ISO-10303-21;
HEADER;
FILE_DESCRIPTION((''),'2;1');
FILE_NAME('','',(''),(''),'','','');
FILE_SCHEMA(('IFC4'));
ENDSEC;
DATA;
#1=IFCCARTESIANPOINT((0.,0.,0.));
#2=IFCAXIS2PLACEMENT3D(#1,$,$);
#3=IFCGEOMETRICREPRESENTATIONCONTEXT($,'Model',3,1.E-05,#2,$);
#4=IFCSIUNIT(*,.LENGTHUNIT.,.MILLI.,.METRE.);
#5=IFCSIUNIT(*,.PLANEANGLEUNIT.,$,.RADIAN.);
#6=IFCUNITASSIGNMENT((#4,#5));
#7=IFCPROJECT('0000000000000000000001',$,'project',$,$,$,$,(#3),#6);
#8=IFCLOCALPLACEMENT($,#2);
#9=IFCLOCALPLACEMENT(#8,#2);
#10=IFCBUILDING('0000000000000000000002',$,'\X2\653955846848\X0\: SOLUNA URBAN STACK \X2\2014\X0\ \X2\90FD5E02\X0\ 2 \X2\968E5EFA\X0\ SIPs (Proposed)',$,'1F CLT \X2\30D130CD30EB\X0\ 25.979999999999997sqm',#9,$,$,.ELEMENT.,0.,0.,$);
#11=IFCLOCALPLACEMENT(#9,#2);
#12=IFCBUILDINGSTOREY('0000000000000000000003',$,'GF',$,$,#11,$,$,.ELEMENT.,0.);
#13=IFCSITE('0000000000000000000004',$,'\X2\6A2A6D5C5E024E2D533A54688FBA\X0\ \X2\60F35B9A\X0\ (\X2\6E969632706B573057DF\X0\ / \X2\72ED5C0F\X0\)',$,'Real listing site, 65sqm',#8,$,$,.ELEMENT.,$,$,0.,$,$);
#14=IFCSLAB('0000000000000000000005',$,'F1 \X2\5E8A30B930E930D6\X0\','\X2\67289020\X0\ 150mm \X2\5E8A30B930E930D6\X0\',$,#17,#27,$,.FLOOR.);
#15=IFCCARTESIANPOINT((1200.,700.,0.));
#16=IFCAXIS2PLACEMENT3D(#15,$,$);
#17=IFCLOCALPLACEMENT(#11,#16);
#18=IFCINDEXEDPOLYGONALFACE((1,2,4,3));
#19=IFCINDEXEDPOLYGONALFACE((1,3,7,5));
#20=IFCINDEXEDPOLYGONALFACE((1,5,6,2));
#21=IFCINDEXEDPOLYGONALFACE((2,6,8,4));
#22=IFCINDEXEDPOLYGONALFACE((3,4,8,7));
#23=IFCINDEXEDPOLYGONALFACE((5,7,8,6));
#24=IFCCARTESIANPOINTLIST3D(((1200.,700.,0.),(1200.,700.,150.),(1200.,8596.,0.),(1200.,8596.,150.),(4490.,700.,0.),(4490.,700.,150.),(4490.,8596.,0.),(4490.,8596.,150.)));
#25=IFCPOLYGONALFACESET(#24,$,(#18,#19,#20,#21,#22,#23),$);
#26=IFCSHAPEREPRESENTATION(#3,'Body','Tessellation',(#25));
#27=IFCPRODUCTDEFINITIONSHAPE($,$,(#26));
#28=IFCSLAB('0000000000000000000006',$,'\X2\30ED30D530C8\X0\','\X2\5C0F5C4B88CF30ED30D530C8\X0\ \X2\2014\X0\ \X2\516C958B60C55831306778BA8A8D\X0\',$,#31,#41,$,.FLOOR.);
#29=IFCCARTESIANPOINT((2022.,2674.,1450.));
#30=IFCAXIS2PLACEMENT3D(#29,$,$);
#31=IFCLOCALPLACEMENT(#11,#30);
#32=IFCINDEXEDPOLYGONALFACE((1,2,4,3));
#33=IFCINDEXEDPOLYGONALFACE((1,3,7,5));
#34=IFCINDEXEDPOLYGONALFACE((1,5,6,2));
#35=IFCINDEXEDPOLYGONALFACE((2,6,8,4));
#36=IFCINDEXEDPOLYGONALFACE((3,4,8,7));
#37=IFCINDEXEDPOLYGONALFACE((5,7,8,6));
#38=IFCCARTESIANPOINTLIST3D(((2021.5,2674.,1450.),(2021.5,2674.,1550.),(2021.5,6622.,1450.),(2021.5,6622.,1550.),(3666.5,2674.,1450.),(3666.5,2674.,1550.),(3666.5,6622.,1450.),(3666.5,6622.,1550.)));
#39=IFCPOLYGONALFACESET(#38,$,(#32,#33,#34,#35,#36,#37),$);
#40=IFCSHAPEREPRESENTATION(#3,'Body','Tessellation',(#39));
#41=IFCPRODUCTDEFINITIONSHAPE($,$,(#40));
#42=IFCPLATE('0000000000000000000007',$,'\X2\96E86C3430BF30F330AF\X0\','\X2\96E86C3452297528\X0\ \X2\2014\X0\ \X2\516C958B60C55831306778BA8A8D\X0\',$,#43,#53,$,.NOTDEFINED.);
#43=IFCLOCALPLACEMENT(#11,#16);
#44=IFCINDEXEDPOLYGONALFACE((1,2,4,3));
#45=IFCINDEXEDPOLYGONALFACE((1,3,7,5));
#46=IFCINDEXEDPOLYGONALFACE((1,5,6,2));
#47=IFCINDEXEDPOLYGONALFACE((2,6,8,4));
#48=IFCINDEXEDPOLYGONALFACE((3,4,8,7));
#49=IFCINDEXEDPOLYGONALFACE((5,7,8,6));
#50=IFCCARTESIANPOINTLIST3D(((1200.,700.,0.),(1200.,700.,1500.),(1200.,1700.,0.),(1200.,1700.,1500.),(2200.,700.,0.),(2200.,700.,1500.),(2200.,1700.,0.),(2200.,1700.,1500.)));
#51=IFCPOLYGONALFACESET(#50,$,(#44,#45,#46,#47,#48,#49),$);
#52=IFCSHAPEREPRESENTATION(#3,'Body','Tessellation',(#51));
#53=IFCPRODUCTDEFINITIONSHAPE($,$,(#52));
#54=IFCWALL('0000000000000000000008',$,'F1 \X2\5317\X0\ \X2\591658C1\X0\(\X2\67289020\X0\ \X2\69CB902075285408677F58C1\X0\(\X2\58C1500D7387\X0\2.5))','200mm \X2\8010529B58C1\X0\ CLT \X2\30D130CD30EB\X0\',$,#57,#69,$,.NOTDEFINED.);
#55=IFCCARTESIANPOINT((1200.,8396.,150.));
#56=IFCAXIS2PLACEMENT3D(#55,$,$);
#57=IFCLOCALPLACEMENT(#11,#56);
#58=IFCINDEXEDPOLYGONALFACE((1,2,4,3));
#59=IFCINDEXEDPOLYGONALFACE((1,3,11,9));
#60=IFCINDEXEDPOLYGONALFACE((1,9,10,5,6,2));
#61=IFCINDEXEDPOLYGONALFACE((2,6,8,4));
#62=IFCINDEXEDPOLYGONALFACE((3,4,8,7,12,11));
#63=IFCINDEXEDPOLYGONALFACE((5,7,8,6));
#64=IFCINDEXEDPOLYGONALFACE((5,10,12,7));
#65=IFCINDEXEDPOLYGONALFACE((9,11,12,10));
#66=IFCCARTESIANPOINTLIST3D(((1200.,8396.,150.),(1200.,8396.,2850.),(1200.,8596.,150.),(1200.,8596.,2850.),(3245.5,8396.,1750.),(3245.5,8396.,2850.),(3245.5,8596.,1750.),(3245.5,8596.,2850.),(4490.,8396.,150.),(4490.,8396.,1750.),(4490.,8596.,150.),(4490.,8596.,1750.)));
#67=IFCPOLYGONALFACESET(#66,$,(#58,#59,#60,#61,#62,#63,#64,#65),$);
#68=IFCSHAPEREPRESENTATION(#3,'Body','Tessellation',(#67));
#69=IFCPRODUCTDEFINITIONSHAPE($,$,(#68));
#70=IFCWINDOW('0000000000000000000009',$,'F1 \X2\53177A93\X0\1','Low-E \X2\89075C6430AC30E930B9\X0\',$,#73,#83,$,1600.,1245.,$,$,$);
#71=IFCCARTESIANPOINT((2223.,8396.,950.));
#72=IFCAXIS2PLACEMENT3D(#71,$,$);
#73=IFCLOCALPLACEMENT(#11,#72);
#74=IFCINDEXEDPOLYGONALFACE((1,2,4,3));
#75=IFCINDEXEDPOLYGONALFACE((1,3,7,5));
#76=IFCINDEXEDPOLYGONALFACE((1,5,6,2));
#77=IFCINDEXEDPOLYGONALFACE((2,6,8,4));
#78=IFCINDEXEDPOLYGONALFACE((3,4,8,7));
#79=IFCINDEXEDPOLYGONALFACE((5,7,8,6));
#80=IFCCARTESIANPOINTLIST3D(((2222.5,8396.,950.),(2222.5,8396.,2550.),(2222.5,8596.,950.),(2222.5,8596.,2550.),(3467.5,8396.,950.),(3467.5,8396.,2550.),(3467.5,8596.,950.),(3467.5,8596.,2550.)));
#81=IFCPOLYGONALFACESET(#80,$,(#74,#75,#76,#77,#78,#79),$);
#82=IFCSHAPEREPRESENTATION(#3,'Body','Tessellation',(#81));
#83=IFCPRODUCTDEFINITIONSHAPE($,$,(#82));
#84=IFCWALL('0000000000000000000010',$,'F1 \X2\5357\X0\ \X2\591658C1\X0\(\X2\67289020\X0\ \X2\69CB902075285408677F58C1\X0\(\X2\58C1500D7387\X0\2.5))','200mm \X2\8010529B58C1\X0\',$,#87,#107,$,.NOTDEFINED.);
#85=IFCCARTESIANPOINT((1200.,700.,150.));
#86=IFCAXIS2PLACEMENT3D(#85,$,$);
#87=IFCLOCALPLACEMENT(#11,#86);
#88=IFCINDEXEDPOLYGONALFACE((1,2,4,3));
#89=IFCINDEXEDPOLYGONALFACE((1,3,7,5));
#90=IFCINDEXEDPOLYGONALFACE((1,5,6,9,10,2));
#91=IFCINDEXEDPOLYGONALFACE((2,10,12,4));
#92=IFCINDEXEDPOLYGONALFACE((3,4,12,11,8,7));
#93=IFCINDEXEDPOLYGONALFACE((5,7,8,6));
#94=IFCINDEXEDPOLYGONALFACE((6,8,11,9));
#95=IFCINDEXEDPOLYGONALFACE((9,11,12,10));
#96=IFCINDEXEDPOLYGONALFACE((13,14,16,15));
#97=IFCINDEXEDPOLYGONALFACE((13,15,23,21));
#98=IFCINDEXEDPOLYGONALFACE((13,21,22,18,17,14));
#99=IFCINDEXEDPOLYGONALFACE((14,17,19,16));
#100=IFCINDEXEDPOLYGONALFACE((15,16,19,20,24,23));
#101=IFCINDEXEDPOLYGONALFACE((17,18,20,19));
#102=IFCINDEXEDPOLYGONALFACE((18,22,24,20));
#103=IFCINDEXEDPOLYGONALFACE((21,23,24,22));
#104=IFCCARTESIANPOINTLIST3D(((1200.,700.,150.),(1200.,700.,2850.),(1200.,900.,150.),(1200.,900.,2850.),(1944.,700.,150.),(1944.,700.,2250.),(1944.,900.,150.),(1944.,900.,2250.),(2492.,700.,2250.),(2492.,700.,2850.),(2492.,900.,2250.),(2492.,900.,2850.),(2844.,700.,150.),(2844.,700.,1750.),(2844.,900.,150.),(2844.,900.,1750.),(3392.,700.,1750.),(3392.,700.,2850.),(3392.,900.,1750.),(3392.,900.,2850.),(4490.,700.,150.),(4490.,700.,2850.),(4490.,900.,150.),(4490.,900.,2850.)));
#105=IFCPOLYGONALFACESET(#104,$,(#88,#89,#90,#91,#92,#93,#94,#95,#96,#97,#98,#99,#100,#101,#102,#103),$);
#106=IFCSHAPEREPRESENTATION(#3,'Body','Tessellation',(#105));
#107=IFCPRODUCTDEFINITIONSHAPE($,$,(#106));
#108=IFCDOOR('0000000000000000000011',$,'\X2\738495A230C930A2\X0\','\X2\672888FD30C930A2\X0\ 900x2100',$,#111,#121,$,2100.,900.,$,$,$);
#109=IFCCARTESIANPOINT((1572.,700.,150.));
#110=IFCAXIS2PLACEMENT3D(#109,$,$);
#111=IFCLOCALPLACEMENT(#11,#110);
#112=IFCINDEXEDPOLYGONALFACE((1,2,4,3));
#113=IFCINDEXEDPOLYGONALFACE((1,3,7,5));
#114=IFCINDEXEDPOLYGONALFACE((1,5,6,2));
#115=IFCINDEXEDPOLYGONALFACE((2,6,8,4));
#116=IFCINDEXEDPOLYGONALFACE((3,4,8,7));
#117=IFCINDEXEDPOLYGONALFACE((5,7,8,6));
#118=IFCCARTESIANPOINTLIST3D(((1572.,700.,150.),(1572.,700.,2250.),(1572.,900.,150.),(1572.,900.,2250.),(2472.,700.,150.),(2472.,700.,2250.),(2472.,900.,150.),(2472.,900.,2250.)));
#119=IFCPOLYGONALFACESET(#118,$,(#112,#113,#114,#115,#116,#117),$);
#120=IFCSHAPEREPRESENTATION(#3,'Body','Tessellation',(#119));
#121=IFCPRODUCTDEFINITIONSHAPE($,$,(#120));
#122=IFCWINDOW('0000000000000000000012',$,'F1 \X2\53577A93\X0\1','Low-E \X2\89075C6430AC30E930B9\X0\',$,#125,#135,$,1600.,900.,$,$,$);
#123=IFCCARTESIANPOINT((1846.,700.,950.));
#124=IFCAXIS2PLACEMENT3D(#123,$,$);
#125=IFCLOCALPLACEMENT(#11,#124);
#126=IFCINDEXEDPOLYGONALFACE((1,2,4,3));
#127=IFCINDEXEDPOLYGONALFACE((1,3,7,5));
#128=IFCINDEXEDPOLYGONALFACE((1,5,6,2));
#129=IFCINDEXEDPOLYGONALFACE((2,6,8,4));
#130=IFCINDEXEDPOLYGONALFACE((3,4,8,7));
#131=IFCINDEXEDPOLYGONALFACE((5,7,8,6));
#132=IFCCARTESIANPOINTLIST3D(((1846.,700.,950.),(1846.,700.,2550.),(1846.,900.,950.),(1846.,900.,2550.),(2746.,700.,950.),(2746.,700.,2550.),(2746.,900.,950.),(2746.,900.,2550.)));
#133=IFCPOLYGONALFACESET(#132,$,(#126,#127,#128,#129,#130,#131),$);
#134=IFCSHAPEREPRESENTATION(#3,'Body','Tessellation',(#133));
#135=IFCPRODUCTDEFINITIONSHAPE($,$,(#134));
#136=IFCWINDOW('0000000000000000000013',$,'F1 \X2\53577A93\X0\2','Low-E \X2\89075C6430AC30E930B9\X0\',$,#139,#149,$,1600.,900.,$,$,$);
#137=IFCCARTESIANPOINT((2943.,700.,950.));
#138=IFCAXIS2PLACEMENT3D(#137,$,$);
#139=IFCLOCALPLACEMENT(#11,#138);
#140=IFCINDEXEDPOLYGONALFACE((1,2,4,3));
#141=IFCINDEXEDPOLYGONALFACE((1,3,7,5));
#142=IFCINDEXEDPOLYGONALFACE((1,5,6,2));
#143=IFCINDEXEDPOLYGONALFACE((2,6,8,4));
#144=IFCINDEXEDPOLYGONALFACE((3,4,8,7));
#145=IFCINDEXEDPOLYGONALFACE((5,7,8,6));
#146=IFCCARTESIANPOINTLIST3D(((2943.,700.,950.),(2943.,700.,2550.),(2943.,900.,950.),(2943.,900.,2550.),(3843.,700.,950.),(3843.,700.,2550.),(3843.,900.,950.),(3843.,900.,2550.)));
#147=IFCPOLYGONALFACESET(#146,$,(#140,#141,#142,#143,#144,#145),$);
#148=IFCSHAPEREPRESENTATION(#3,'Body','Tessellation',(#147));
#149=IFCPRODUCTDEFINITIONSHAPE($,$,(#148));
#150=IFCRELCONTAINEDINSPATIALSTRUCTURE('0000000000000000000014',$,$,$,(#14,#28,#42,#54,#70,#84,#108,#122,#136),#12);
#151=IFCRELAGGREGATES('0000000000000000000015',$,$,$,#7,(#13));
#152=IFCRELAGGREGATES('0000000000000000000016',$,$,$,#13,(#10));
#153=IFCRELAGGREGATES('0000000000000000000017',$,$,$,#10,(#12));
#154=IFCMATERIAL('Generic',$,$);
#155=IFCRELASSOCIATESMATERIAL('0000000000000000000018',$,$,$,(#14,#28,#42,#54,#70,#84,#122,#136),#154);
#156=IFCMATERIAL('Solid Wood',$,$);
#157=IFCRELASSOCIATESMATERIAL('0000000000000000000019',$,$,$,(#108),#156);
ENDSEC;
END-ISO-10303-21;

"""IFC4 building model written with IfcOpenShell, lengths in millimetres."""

from ifc_helpers import new_model, si_unit, frame, frame_2d, origin, place, context, project, spatial, rectangle, extrude, material, element, fill, save


model = new_model("IFC4")

# Units and contexts
model_context = context("Model", 3, precision=1e-05, world=origin())
ifc_project = project(units=[si_unit("LENGTHUNIT", "METRE", prefix="MILLI"), si_unit("PLANEANGLEUNIT", "RADIAN")], contexts=[model_context])

# Site, building, storey
site_placement = place(None, origin())
site = spatial("IfcSite", under=ifc_project, at=site_placement, Name="横浜市中区周辺 想定 (準防火地域 / 狭小)", ObjectType="Real listing site, 65sqm", CompositionType="ELEMENT", RefElevation=0.0)
building_placement = place(site_placement, origin())
building = spatial("IfcBuilding", under=site, at=building_placement, Name="改善案: SOLUNA URBAN STACK — 都市 2 階建 SIPs (Proposed)", ObjectType="1F CLT パネル 25.979999999999997sqm", CompositionType="ELEMENT", ElevationOfRefHeight=0.0, ElevationOfTerrain=0.0)
storey_placement = place(building_placement, origin())
storey = spatial("IfcBuildingStorey", under=building, at=storey_placement, Name="GF", CompositionType="ELEMENT", Elevation=0.0)

# Slabs
ifc_material_1 = material(Name="Generic")
slab_1_placement = place(storey_placement, frame((1200.0, 700.0, 0.0)))
element("IfcSlab", 1, at=slab_1_placement, inside=storey, material=ifc_material_1, Name="F1 床スラブ", Description="木造 150mm 床スラブ", PredefinedType="FLOOR", context=model_context, shape_type="SweptSolid", body=[
    extrude(rectangle(XDim=3290.0, YDim=7896.0, at=frame_2d((1645.0, 3948.0))), frame((1200.0, 700.0, 0.0)), (0.0, 0.0, 1.0), 150.0),
])
slab_2_placement = place(storey_placement, frame((2022.0, 2674.0, 1450.0)))
element("IfcSlab", 2, at=slab_2_placement, inside=storey, material=ifc_material_1, Name="ロフト", Description="小屋裏ロフト — 公開情報で確認", PredefinedType="FLOOR", context=model_context, shape_type="SweptSolid", body=[
    extrude(rectangle(XDim=1645.0, YDim=3948.0, at=frame_2d((822.0, 1974.0))), frame((2022.0, 2674.0, 1450.0)), (0.0, 0.0, 1.0), 100.0),
])

# Plate
plate_placement = place(storey_placement, frame((1200.0, 700.0, 0.0)))
element("IfcPlate", 3, at=plate_placement, inside=storey, material=ifc_material_1, Name="雨水タンク", Description="雨水利用 — 公開情報で確認", PredefinedType="NOTDEFINED", context=model_context, shape_type="SweptSolid", body=[
    extrude(rectangle(XDim=1000.0, YDim=1000.0, at=frame_2d((500.0, 500.0))), frame((1200.0, 700.0, 0.0)), (0.0, 0.0, 1.0), 1500.0),
])

# Wall, opening, window
wall_1_placement = place(storey_placement, frame((1200.0, 8396.0, 150.0)))
wall_1 = element("IfcWall", 4, at=wall_1_placement, inside=storey, material=ifc_material_1, Name="F1 北 外壁(木造 構造用合板壁(壁倍率2.5))", Description="200mm 耐力壁 CLT パネル", PredefinedType="NOTDEFINED", context=model_context, shape_type="SweptSolid", body=[
    extrude(rectangle(XDim=3290.0, YDim=200.0, at=frame_2d((1645.0, 100.0))), frame((1200.0, 8396.0, 150.0)), (0.0, 0.0, 1.0), 2700.0),
])
opening_1_placement = place(storey_placement, frame((2223.0, 8396.0, 950.0)))
opening_1 = element("IfcOpeningElement", 5, at=opening_1_placement, cuts=wall_1, PredefinedType="NOTDEFINED", context=model_context, shape_type="SweptSolid", body=[
    extrude(rectangle(XDim=1245.0, YDim=200.0, at=frame_2d((622.0, 100.0))), frame((2223.0, 8396.0, 950.0)), (0.0, 0.0, 1.0), 1600.0),
])
window_1_placement = place(storey_placement, frame((2223.0, 8396.0, 950.0)))
window_1 = element("IfcWindow", 6, at=window_1_placement, inside=storey, material=ifc_material_1, Name="F1 北窓1", Description="Low-E 複層ガラス", OverallHeight=1600.0, OverallWidth=1245.0, context=model_context, shape_type="SweptSolid", body=[
    extrude(rectangle(XDim=1245.0, YDim=200.0, at=frame_2d((622.0, 100.0))), frame((2223.0, 8396.0, 950.0)), (0.0, 0.0, 1.0), 1600.0),
])
fill(opening_1, window_1)

# Wall, openings, door, windows
wall_2_placement = place(storey_placement, frame((1200.0, 700.0, 150.0)))
wall_2 = element("IfcWall", 7, at=wall_2_placement, inside=storey, material=ifc_material_1, Name="F1 南 外壁(木造 構造用合板壁(壁倍率2.5))", Description="200mm 耐力壁", PredefinedType="NOTDEFINED", context=model_context, shape_type="SweptSolid", body=[
    extrude(rectangle(XDim=3290.0, YDim=200.0, at=frame_2d((1645.0, 100.0))), frame((1200.0, 700.0, 150.0)), (0.0, 0.0, 1.0), 2700.0),
])
opening_2_placement = place(storey_placement, frame((1572.0, 700.0, 150.0)))
opening_2 = element("IfcOpeningElement", 8, at=opening_2_placement, cuts=wall_2, PredefinedType="NOTDEFINED", context=model_context, shape_type="SweptSolid", body=[
    extrude(rectangle(XDim=900.0, YDim=200.0, at=frame_2d((450.0, 100.0))), frame((1572.0, 700.0, 150.0)), (0.0, 0.0, 1.0), 2100.0),
])
opening_3_placement = place(storey_placement, frame((1846.0, 700.0, 950.0)))
opening_3 = element("IfcOpeningElement", 9, at=opening_3_placement, cuts=wall_2, PredefinedType="NOTDEFINED", context=model_context, shape_type="SweptSolid", body=[
    extrude(rectangle(XDim=900.0, YDim=200.0, at=frame_2d((450.0, 100.0))), frame((1846.0, 700.0, 950.0)), (0.0, 0.0, 1.0), 1600.0),
])
opening_4_placement = place(storey_placement, frame((2943.0, 700.0, 950.0)))
opening_4 = element("IfcOpeningElement", 10, at=opening_4_placement, cuts=wall_2, PredefinedType="NOTDEFINED", context=model_context, shape_type="SweptSolid", body=[
    extrude(rectangle(XDim=900.0, YDim=200.0, at=frame_2d((450.0, 100.0))), frame((2943.0, 700.0, 950.0)), (0.0, 0.0, 1.0), 1600.0),
])
ifc_material_2 = material(Name="Solid Wood")
door_placement = place(storey_placement, frame((1572.0, 700.0, 150.0)))
door = element("IfcDoor", 11, at=door_placement, inside=storey, material=ifc_material_2, Name="玄関ドア", Description="木製ドア 900x2100", OverallHeight=2100.0, OverallWidth=900.0, context=model_context, shape_type="SweptSolid", body=[
    extrude(rectangle(XDim=900.0, YDim=200.0, at=frame_2d((450.0, 100.0))), frame((1572.0, 700.0, 150.0)), (0.0, 0.0, 1.0), 2100.0),
])
fill(opening_2, door)
window_2_placement = place(storey_placement, frame((1846.0, 700.0, 950.0)))
window_2 = element("IfcWindow", 12, at=window_2_placement, inside=storey, material=ifc_material_1, Name="F1 南窓1", Description="Low-E 複層ガラス", OverallHeight=1600.0, OverallWidth=900.0, context=model_context, shape_type="SweptSolid", body=[
    extrude(rectangle(XDim=900.0, YDim=200.0, at=frame_2d((450.0, 100.0))), frame((1846.0, 700.0, 950.0)), (0.0, 0.0, 1.0), 1600.0),
])
fill(opening_3, window_2)
window_3_placement = place(storey_placement, frame((2943.0, 700.0, 950.0)))
window_3 = element("IfcWindow", 13, at=window_3_placement, inside=storey, material=ifc_material_1, Name="F1 南窓2", Description="Low-E 複層ガラス", OverallHeight=1600.0, OverallWidth=900.0, context=model_context, shape_type="SweptSolid", body=[
    extrude(rectangle(XDim=900.0, YDim=200.0, at=frame_2d((450.0, 100.0))), frame((2943.0, 700.0, 950.0)), (0.0, 0.0, 1.0), 1600.0),
])
fill(opening_4, window_3)

save(model, "model.ifc")
